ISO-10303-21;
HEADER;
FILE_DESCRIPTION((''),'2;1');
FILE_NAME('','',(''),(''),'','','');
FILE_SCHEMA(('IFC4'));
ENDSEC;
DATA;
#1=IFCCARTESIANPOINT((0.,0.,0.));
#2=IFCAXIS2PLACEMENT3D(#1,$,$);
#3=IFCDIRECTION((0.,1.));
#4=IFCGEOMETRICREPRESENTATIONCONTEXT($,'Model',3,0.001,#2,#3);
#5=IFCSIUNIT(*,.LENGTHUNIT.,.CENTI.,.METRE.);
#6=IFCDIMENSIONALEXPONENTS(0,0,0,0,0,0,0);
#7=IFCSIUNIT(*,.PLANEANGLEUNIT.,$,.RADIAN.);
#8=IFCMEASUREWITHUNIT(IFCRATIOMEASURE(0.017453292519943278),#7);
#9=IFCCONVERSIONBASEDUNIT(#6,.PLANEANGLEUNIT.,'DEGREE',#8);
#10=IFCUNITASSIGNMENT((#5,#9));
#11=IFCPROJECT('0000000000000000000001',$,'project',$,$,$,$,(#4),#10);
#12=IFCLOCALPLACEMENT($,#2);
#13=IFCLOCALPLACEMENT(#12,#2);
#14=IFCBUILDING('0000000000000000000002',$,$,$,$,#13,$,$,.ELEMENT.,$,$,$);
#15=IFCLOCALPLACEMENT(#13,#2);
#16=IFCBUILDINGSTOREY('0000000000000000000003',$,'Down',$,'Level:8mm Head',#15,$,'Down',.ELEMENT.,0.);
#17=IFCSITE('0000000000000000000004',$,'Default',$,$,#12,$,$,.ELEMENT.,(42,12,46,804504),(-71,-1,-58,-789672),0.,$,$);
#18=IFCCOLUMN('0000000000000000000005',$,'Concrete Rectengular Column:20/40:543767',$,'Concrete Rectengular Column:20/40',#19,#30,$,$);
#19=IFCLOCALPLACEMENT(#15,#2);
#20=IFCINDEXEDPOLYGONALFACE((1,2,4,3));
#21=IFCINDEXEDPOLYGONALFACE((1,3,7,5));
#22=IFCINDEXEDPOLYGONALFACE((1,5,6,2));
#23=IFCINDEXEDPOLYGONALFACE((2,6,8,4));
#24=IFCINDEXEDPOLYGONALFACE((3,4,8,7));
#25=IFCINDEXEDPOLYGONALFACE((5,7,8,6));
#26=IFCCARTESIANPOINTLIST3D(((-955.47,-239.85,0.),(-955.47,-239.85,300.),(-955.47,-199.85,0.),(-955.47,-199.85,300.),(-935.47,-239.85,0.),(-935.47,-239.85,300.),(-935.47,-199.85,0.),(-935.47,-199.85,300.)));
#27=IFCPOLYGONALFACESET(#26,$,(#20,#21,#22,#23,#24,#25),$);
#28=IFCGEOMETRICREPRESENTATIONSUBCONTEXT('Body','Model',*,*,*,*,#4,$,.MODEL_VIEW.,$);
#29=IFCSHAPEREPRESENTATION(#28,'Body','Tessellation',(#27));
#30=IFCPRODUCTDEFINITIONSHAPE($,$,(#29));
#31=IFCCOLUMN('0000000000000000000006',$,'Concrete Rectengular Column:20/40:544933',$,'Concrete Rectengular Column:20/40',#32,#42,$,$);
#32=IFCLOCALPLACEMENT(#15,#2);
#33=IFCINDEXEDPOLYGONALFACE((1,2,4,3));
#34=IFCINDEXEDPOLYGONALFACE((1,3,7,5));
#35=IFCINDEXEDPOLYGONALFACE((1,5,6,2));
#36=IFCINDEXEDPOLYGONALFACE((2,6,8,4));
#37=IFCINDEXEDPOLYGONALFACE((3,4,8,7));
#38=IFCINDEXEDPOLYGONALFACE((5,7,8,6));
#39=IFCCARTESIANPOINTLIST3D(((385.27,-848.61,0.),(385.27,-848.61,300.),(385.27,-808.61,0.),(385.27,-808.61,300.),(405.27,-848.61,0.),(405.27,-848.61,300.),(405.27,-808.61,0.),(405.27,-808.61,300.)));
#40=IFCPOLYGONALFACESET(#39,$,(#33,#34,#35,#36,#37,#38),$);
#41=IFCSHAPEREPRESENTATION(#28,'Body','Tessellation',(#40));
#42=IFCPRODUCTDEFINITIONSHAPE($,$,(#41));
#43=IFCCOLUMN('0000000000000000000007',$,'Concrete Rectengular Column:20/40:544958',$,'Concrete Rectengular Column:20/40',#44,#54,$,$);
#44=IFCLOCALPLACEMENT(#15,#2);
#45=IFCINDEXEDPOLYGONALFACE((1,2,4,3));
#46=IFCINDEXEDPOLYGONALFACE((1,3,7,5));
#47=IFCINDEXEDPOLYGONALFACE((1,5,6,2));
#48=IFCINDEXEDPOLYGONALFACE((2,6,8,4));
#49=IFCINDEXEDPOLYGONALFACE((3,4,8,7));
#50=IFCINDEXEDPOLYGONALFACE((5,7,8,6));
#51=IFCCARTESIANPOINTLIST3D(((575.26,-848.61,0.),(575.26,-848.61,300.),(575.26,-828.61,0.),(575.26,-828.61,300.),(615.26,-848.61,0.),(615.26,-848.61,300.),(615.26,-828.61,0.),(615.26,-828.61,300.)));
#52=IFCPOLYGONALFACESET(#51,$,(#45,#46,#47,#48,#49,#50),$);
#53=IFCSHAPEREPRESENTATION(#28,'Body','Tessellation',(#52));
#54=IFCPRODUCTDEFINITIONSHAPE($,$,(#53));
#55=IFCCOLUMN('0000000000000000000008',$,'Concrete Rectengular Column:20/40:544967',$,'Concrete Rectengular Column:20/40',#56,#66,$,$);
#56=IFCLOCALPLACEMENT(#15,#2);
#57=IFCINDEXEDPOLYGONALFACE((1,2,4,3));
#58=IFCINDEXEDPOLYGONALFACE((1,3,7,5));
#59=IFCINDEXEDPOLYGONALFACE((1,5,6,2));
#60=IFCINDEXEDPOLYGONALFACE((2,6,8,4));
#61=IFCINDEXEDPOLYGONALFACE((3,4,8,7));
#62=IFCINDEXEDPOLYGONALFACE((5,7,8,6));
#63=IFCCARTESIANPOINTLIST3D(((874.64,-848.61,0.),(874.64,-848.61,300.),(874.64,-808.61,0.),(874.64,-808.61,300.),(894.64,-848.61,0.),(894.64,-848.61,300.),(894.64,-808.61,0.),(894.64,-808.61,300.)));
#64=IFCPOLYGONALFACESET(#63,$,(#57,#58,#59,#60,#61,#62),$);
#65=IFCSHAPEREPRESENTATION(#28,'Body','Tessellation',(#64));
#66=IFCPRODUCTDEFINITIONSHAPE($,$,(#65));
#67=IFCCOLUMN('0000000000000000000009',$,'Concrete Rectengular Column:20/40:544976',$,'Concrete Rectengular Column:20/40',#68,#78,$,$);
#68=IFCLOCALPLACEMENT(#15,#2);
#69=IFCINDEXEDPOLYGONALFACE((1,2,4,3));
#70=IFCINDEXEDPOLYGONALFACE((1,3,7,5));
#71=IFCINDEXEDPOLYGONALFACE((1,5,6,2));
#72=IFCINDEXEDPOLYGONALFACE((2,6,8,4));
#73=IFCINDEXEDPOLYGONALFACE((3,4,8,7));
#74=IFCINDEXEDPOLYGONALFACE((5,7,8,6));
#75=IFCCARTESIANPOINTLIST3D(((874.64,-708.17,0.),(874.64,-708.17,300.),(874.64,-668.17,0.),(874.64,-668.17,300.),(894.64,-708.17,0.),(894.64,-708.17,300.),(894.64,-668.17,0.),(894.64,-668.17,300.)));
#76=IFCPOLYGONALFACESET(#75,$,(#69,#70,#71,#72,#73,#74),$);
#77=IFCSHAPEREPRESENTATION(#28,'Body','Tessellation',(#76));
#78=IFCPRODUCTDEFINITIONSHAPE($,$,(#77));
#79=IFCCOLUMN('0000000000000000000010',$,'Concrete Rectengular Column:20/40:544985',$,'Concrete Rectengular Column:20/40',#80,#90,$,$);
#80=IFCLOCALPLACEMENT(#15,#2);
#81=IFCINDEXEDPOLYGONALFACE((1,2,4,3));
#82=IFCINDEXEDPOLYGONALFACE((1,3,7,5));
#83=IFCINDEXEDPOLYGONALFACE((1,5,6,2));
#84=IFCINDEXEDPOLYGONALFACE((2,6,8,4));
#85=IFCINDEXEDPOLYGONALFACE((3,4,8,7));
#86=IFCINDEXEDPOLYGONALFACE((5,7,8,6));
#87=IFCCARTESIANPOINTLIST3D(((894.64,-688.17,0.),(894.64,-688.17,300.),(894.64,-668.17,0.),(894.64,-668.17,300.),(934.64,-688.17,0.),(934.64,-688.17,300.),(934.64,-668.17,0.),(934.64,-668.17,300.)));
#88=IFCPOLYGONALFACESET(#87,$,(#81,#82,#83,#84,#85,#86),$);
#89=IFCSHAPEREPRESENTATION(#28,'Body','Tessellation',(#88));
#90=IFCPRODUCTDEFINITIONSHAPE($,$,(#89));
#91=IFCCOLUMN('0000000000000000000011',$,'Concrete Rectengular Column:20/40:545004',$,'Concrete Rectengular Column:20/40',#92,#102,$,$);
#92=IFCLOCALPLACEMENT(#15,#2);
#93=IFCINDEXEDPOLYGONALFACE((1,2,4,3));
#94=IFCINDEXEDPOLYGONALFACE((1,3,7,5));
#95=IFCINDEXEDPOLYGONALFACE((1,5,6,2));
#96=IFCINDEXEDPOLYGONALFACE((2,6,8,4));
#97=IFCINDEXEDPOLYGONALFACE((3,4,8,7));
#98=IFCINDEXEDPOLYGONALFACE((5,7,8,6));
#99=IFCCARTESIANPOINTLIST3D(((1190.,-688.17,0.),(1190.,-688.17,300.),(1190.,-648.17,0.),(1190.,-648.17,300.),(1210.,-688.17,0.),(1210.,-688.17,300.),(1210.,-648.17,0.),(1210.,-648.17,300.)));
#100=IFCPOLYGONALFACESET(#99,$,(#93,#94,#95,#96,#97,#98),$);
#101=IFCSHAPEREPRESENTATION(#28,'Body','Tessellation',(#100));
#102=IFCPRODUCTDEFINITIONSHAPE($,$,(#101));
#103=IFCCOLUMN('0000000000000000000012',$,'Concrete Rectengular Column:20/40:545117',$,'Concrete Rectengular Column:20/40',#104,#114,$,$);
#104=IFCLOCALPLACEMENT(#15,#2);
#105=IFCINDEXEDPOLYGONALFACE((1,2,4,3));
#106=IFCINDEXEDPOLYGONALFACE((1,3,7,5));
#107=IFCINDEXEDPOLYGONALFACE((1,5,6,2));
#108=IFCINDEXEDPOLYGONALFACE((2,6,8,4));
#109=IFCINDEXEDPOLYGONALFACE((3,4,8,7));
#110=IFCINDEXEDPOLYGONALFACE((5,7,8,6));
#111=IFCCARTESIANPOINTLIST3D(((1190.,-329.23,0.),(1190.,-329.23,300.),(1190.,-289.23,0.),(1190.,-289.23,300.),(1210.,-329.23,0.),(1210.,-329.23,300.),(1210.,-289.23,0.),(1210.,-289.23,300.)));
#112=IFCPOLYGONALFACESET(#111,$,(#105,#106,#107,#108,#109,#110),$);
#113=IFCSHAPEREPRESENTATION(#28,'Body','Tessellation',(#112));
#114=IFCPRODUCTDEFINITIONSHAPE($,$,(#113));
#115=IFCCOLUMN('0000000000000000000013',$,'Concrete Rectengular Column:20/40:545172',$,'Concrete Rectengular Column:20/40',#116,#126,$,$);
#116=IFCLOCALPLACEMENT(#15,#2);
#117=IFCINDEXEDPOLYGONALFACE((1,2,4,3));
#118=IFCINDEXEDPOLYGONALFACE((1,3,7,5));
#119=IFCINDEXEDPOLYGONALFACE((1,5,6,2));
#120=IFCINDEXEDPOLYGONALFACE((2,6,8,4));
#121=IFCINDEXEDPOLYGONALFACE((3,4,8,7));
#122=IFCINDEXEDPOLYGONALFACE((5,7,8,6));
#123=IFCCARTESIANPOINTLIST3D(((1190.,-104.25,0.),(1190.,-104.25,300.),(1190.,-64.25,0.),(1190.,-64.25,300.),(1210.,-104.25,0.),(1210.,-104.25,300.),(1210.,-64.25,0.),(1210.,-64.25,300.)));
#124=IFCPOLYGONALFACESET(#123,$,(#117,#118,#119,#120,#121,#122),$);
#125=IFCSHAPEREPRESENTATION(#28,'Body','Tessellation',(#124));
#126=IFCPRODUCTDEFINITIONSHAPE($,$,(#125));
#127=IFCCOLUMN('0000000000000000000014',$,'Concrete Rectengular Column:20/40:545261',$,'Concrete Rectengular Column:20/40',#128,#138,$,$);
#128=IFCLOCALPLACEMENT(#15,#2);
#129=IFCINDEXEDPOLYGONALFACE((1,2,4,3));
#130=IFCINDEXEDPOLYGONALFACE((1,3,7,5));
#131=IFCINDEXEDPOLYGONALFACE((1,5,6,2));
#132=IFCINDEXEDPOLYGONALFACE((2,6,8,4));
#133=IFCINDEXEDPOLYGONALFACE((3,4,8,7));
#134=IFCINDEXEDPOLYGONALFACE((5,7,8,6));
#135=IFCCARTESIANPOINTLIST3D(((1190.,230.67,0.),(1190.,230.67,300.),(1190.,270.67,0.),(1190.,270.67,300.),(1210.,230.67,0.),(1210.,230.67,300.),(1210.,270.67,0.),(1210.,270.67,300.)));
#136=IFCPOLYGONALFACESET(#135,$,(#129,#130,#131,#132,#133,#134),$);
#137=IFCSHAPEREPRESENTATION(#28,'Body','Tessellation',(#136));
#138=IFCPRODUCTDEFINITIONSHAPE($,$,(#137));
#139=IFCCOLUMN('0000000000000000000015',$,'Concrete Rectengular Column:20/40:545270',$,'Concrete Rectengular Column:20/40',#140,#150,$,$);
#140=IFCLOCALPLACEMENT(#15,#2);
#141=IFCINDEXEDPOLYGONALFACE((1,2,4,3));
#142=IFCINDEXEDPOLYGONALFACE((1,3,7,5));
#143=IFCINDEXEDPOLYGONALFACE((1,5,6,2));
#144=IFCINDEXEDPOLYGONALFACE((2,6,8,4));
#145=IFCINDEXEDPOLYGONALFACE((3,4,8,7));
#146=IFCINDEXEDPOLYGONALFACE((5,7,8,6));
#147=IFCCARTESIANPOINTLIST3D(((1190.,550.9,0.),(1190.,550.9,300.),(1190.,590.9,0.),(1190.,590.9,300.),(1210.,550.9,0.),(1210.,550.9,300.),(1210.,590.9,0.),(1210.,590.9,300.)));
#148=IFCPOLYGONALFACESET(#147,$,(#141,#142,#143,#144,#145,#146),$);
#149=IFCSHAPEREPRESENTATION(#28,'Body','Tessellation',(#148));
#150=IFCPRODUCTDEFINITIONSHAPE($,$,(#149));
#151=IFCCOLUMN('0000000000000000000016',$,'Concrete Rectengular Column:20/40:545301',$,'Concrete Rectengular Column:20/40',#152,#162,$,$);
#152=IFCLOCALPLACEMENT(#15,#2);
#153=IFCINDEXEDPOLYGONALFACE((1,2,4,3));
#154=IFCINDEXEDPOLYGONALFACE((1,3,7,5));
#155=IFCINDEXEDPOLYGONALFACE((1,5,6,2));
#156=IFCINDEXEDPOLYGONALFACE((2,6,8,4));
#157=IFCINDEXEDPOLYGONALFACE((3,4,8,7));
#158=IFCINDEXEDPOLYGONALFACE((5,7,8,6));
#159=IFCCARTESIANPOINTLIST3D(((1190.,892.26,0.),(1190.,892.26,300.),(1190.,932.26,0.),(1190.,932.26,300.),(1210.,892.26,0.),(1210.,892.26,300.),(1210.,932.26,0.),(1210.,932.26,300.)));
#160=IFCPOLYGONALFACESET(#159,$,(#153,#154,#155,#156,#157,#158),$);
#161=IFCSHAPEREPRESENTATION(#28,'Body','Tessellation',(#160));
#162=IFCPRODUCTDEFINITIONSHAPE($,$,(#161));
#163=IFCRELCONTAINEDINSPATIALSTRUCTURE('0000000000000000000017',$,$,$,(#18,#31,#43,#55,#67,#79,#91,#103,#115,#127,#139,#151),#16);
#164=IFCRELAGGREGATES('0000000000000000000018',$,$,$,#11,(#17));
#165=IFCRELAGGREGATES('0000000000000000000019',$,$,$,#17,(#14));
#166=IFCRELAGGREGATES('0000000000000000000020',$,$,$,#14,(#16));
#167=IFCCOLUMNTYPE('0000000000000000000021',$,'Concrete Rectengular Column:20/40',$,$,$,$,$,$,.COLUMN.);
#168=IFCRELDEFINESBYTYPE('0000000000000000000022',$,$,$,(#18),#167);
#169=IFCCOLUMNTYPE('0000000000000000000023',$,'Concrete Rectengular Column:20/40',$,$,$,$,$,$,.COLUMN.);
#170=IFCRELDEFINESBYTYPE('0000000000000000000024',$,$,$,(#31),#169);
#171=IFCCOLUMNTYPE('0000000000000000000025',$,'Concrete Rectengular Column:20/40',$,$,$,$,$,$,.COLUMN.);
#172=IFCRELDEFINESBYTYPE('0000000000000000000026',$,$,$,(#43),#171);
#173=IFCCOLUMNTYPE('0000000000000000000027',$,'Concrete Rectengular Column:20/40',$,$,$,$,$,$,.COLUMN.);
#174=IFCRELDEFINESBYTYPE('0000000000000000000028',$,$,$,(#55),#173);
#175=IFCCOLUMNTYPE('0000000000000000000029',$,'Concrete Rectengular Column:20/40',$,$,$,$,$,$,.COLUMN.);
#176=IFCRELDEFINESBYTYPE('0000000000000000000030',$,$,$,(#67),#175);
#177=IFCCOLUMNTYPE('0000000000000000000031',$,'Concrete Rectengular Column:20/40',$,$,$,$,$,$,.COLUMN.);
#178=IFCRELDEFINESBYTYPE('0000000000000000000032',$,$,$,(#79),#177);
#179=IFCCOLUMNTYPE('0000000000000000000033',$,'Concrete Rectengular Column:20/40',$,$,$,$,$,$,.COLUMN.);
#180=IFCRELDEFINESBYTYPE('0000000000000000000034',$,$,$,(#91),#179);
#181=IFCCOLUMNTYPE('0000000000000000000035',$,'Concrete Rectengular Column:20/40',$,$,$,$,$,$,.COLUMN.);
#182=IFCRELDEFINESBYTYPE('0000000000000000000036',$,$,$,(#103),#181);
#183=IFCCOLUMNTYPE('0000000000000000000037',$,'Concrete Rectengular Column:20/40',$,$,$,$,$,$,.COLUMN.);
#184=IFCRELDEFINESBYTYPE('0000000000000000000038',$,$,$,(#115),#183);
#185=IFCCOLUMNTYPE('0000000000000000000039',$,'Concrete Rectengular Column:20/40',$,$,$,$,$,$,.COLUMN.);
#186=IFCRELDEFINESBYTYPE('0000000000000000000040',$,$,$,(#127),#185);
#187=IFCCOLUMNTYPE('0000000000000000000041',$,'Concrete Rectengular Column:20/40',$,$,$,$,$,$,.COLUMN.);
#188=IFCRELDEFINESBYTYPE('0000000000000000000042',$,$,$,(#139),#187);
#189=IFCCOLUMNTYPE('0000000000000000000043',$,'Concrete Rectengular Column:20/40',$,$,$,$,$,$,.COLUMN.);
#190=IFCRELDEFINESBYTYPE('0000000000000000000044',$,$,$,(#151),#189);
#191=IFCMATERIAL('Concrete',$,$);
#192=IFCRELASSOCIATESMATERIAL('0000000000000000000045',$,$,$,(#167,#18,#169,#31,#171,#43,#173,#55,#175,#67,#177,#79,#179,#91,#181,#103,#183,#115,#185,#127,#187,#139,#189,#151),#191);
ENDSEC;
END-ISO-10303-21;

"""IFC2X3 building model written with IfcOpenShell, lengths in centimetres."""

from ifc_helpers import new_model, entity, si_unit, converted_unit, direction, frame, frame_2d, origin, origin_2d_with_axis, place, context, subcontext, project, spatial, rectangle, extrude, source, transform, mapped, material, type_object, type_shapes, element, save


model = new_model("IFC2X3")

# Units and contexts
model_context = context("Model", 3, precision=0.001, world=origin(), true_north=direction((0.0, 1.0)))
body_context = subcontext(model_context, "Body", "Model", "MODEL_VIEW")
ifc_project = project(units=[si_unit("LENGTHUNIT", "METRE", prefix="CENTI"), converted_unit("PLANEANGLEUNIT", "DEGREE", entity("IfcRatioMeasure", 0.017453292519943278), si_unit("PLANEANGLEUNIT", "RADIAN"), dimensions=[0, 0, 0, 0, 0, 0, 0])], contexts=[model_context])

# Site, building, storey
site_placement = place(None, origin())
site = spatial("IfcSite", under=ifc_project, at=site_placement, Name="Default", CompositionType="ELEMENT", RefLatitude=(42, 12, 46, 804504), RefLongitude=(-71, -1, -58, -789672), RefElevation=0.0)
building_placement = place(site_placement, origin())
building = spatial("IfcBuilding", under=site, at=building_placement, CompositionType="ELEMENT")
storey_placement = place(building_placement, origin())
storey = spatial("IfcBuildingStorey", under=building, at=storey_placement, Name="Down", ObjectType="Level:8mm Head", LongName="Down", CompositionType="ELEMENT", Elevation=0.0)

# Columns
ifc_material = material(Name="Concrete")
column_type_1 = type_object("IfcColumnType", Name="Concrete Rectengular Column:20/40", PredefinedType="COLUMN", material=ifc_material)
shared_shape_1 = source(origin(), body_context, "Body", "SweptSolid", [
    extrude(rectangle(XDim=40.0, YDim=20.0, at=origin_2d_with_axis()), frame((-945.47, -219.85, 0.0), z_axis=(0.0, 0.0, 1.0), x_axis=(0.0, -1.0, 0.0)), (0.0, 0.0, 1.0), 300.0),
])
type_shapes(column_type_1, [shared_shape_1])
column_1_placement = place(storey_placement, origin())
element("IfcColumn", 1, at=column_1_placement, inside=storey, type_object=column_type_1, material=ifc_material, Name="Concrete Rectengular Column:20/40:543767", ObjectType="Concrete Rectengular Column:20/40", context=body_context, shape_type="MappedRepresentation", body=[
    mapped(shared_shape_1, transform((0.0, 0.0, 0.0), scale=1.0)),
])
column_type_2 = type_object("IfcColumnType", Name="Concrete Rectengular Column:20/40", PredefinedType="COLUMN", material=ifc_material)
shared_shape_2 = source(origin(), body_context, "Body", "SweptSolid", [
    extrude(rectangle(XDim=40.0, YDim=20.0, at=origin_2d_with_axis()), frame((395.27, -828.61, 0.0), z_axis=(0.0, 0.0, 1.0), x_axis=(0.0, -1.0, 0.0)), (0.0, 0.0, 1.0), 300.0),
])
type_shapes(column_type_2, [shared_shape_2])
column_2_placement = place(storey_placement, origin())
element("IfcColumn", 2, at=column_2_placement, inside=storey, type_object=column_type_2, material=ifc_material, Name="Concrete Rectengular Column:20/40:544933", ObjectType="Concrete Rectengular Column:20/40", context=body_context, shape_type="MappedRepresentation", body=[
    mapped(shared_shape_2, transform((0.0, 0.0, 0.0), scale=1.0)),
])
column_type_3 = type_object("IfcColumnType", Name="Concrete Rectengular Column:20/40", PredefinedType="COLUMN", material=ifc_material)
shared_shape_3 = source(origin(), body_context, "Body", "SweptSolid", [
    extrude(rectangle(XDim=20.0, YDim=40.0, at=origin_2d_with_axis()), frame((595.26, -838.61, 0.0), z_axis=(0.0, 0.0, 1.0), x_axis=(0.0, -1.0, 0.0)), (0.0, 0.0, 1.0), 300.0),
])
type_shapes(column_type_3, [shared_shape_3])
column_3_placement = place(storey_placement, origin())
element("IfcColumn", 3, at=column_3_placement, inside=storey, type_object=column_type_3, material=ifc_material, Name="Concrete Rectengular Column:20/40:544958", ObjectType="Concrete Rectengular Column:20/40", context=body_context, shape_type="MappedRepresentation", body=[
    mapped(shared_shape_3, transform((0.0, 0.0, 0.0), scale=1.0)),
])
column_type_4 = type_object("IfcColumnType", Name="Concrete Rectengular Column:20/40", PredefinedType="COLUMN", material=ifc_material)
shared_shape_4 = source(origin(), body_context, "Body", "SweptSolid", [
    extrude(rectangle(XDim=40.0, YDim=20.0, at=origin_2d_with_axis()), frame((884.64, -828.61, 0.0), z_axis=(0.0, 0.0, 1.0), x_axis=(0.0, -1.0, 0.0)), (0.0, 0.0, 1.0), 300.0),
])
type_shapes(column_type_4, [shared_shape_4])
column_4_placement = place(storey_placement, origin())
element("IfcColumn", 4, at=column_4_placement, inside=storey, type_object=column_type_4, material=ifc_material, Name="Concrete Rectengular Column:20/40:544967", ObjectType="Concrete Rectengular Column:20/40", context=body_context, shape_type="MappedRepresentation", body=[
    mapped(shared_shape_4, transform((0.0, 0.0, 0.0), scale=1.0)),
])
column_type_5 = type_object("IfcColumnType", Name="Concrete Rectengular Column:20/40", PredefinedType="COLUMN", material=ifc_material)
shared_shape_5 = source(origin(), body_context, "Body", "SweptSolid", [
    extrude(rectangle(XDim=40.0, YDim=20.0, at=frame_2d((0.0, 0.0), x_axis=(1.0, 0.0))), frame((884.64, -688.17, 0.0), z_axis=(0.0, 0.0, 1.0), x_axis=(0.0, -1.0, 0.0)), (0.0, 0.0, 1.0), 300.0),
])
type_shapes(column_type_5, [shared_shape_5])
column_5_placement = place(storey_placement, origin())
element("IfcColumn", 5, at=column_5_placement, inside=storey, type_object=column_type_5, material=ifc_material, Name="Concrete Rectengular Column:20/40:544976", ObjectType="Concrete Rectengular Column:20/40", context=body_context, shape_type="MappedRepresentation", body=[
    mapped(shared_shape_5, transform((0.0, 0.0, 0.0), scale=1.0)),
])
column_type_6 = type_object("IfcColumnType", Name="Concrete Rectengular Column:20/40", PredefinedType="COLUMN", material=ifc_material)
shared_shape_6 = source(origin(), body_context, "Body", "SweptSolid", [
    extrude(rectangle(XDim=20.0, YDim=40.0, at=origin_2d_with_axis()), frame((914.64, -678.17, 0.0), z_axis=(0.0, 0.0, 1.0), x_axis=(0.0, -1.0, 0.0)), (0.0, 0.0, 1.0), 300.0),
])
type_shapes(column_type_6, [shared_shape_6])
column_6_placement = place(storey_placement, origin())
element("IfcColumn", 6, at=column_6_placement, inside=storey, type_object=column_type_6, material=ifc_material, Name="Concrete Rectengular Column:20/40:544985", ObjectType="Concrete Rectengular Column:20/40", context=body_context, shape_type="MappedRepresentation", body=[
    mapped(shared_shape_6, transform((0.0, 0.0, 0.0), scale=1.0)),
])
column_type_7 = type_object("IfcColumnType", Name="Concrete Rectengular Column:20/40", PredefinedType="COLUMN", material=ifc_material)
shared_shape_7 = source(origin(), body_context, "Body", "SweptSolid", [
    extrude(rectangle(XDim=40.0, YDim=20.0, at=frame_2d((0.0, 0.0), x_axis=(1.0, 0.0))), frame((1200.0, -668.17, 0.0), z_axis=(0.0, 0.0, 1.0), x_axis=(0.0, -1.0, 0.0)), (0.0, 0.0, 1.0), 300.0),
])
type_shapes(column_type_7, [shared_shape_7])
column_7_placement = place(storey_placement, origin())
element("IfcColumn", 7, at=column_7_placement, inside=storey, type_object=column_type_7, material=ifc_material, Name="Concrete Rectengular Column:20/40:545004", ObjectType="Concrete Rectengular Column:20/40", context=body_context, shape_type="MappedRepresentation", body=[
    mapped(shared_shape_7, transform((0.0, 0.0, 0.0), scale=1.0)),
])
column_type_8 = type_object("IfcColumnType", Name="Concrete Rectengular Column:20/40", PredefinedType="COLUMN", material=ifc_material)
shared_shape_8 = source(origin(), body_context, "Body", "SweptSolid", [
    extrude(rectangle(XDim=40.0, YDim=20.0, at=frame_2d((0.0, 0.0), x_axis=(1.0, 0.0))), frame((1200.0, -309.23, 0.0), z_axis=(0.0, 0.0, 1.0), x_axis=(0.0, -1.0, 0.0)), (0.0, 0.0, 1.0), 300.0),
])
type_shapes(column_type_8, [shared_shape_8])
column_8_placement = place(storey_placement, origin())
element("IfcColumn", 8, at=column_8_placement, inside=storey, type_object=column_type_8, material=ifc_material, Name="Concrete Rectengular Column:20/40:545117", ObjectType="Concrete Rectengular Column:20/40", context=body_context, shape_type="MappedRepresentation", body=[
    mapped(shared_shape_8, transform((0.0, 0.0, 0.0), scale=1.0)),
])
column_type_9 = type_object("IfcColumnType", Name="Concrete Rectengular Column:20/40", PredefinedType="COLUMN", material=ifc_material)
shared_shape_9 = source(origin(), body_context, "Body", "SweptSolid", [
    extrude(rectangle(XDim=40.0, YDim=20.0, at=frame_2d((0.0, 0.0), x_axis=(1.0, 0.0))), frame((1200.0, -84.25, 0.0), z_axis=(0.0, 0.0, 1.0), x_axis=(0.0, -1.0, 0.0)), (0.0, 0.0, 1.0), 300.0),
])
type_shapes(column_type_9, [shared_shape_9])
column_9_placement = place(storey_placement, origin())
element("IfcColumn", 9, at=column_9_placement, inside=storey, type_object=column_type_9, material=ifc_material, Name="Concrete Rectengular Column:20/40:545172", ObjectType="Concrete Rectengular Column:20/40", context=body_context, shape_type="MappedRepresentation", body=[
    mapped(shared_shape_9, transform((0.0, 0.0, 0.0), scale=1.0)),
])
column_type_10 = type_object("IfcColumnType", Name="Concrete Rectengular Column:20/40", PredefinedType="COLUMN", material=ifc_material)
shared_shape_10 = source(origin(), body_context, "Body", "SweptSolid", [
    extrude(rectangle(XDim=40.0, YDim=20.0, at=frame_2d((0.0, 0.0), x_axis=(1.0, 0.0))), frame((1200.0, 250.67, 0.0), z_axis=(0.0, 0.0, 1.0), x_axis=(0.0, -1.0, 0.0)), (0.0, 0.0, 1.0), 300.0),
])
type_shapes(column_type_10, [shared_shape_10])
column_10_placement = place(storey_placement, origin())
element("IfcColumn", 10, at=column_10_placement, inside=storey, type_object=column_type_10, material=ifc_material, Name="Concrete Rectengular Column:20/40:545261", ObjectType="Concrete Rectengular Column:20/40", context=body_context, shape_type="MappedRepresentation", body=[
    mapped(shared_shape_10, transform((0.0, 0.0, 0.0), scale=1.0)),
])
column_type_11 = type_object("IfcColumnType", Name="Concrete Rectengular Column:20/40", PredefinedType="COLUMN", material=ifc_material)
shared_shape_11 = source(origin(), body_context, "Body", "SweptSolid", [
    extrude(rectangle(XDim=40.0, YDim=20.0, at=frame_2d((0.0, 0.0), x_axis=(1.0, 0.0))), frame((1200.0, 570.9, 0.0), z_axis=(0.0, 0.0, 1.0), x_axis=(0.0, -1.0, 0.0)), (0.0, 0.0, 1.0), 300.0),
])
type_shapes(column_type_11, [shared_shape_11])
column_11_placement = place(storey_placement, origin())
element("IfcColumn", 11, at=column_11_placement, inside=storey, type_object=column_type_11, material=ifc_material, Name="Concrete Rectengular Column:20/40:545270", ObjectType="Concrete Rectengular Column:20/40", context=body_context, shape_type="MappedRepresentation", body=[
    mapped(shared_shape_11, transform((0.0, 0.0, 0.0), scale=1.0)),
])
column_type_12 = type_object("IfcColumnType", Name="Concrete Rectengular Column:20/40", PredefinedType="COLUMN", material=ifc_material)
shared_shape_12 = source(origin(), body_context, "Body", "SweptSolid", [
    extrude(rectangle(XDim=40.0, YDim=20.0, at=frame_2d((0.0, 0.0), x_axis=(1.0, 0.0))), frame((1200.0, 912.26, 0.0), z_axis=(0.0, 0.0, 1.0), x_axis=(0.0, -1.0, 0.0)), (0.0, 0.0, 1.0), 300.0),
])
type_shapes(column_type_12, [shared_shape_12])
column_12_placement = place(storey_placement, origin())
element("IfcColumn", 12, at=column_12_placement, inside=storey, type_object=column_type_12, material=ifc_material, Name="Concrete Rectengular Column:20/40:545301", ObjectType="Concrete Rectengular Column:20/40", context=body_context, shape_type="MappedRepresentation", body=[
    mapped(shared_shape_12, transform((0.0, 0.0, 0.0), scale=1.0)),
])

save(model, "model.ifc")
